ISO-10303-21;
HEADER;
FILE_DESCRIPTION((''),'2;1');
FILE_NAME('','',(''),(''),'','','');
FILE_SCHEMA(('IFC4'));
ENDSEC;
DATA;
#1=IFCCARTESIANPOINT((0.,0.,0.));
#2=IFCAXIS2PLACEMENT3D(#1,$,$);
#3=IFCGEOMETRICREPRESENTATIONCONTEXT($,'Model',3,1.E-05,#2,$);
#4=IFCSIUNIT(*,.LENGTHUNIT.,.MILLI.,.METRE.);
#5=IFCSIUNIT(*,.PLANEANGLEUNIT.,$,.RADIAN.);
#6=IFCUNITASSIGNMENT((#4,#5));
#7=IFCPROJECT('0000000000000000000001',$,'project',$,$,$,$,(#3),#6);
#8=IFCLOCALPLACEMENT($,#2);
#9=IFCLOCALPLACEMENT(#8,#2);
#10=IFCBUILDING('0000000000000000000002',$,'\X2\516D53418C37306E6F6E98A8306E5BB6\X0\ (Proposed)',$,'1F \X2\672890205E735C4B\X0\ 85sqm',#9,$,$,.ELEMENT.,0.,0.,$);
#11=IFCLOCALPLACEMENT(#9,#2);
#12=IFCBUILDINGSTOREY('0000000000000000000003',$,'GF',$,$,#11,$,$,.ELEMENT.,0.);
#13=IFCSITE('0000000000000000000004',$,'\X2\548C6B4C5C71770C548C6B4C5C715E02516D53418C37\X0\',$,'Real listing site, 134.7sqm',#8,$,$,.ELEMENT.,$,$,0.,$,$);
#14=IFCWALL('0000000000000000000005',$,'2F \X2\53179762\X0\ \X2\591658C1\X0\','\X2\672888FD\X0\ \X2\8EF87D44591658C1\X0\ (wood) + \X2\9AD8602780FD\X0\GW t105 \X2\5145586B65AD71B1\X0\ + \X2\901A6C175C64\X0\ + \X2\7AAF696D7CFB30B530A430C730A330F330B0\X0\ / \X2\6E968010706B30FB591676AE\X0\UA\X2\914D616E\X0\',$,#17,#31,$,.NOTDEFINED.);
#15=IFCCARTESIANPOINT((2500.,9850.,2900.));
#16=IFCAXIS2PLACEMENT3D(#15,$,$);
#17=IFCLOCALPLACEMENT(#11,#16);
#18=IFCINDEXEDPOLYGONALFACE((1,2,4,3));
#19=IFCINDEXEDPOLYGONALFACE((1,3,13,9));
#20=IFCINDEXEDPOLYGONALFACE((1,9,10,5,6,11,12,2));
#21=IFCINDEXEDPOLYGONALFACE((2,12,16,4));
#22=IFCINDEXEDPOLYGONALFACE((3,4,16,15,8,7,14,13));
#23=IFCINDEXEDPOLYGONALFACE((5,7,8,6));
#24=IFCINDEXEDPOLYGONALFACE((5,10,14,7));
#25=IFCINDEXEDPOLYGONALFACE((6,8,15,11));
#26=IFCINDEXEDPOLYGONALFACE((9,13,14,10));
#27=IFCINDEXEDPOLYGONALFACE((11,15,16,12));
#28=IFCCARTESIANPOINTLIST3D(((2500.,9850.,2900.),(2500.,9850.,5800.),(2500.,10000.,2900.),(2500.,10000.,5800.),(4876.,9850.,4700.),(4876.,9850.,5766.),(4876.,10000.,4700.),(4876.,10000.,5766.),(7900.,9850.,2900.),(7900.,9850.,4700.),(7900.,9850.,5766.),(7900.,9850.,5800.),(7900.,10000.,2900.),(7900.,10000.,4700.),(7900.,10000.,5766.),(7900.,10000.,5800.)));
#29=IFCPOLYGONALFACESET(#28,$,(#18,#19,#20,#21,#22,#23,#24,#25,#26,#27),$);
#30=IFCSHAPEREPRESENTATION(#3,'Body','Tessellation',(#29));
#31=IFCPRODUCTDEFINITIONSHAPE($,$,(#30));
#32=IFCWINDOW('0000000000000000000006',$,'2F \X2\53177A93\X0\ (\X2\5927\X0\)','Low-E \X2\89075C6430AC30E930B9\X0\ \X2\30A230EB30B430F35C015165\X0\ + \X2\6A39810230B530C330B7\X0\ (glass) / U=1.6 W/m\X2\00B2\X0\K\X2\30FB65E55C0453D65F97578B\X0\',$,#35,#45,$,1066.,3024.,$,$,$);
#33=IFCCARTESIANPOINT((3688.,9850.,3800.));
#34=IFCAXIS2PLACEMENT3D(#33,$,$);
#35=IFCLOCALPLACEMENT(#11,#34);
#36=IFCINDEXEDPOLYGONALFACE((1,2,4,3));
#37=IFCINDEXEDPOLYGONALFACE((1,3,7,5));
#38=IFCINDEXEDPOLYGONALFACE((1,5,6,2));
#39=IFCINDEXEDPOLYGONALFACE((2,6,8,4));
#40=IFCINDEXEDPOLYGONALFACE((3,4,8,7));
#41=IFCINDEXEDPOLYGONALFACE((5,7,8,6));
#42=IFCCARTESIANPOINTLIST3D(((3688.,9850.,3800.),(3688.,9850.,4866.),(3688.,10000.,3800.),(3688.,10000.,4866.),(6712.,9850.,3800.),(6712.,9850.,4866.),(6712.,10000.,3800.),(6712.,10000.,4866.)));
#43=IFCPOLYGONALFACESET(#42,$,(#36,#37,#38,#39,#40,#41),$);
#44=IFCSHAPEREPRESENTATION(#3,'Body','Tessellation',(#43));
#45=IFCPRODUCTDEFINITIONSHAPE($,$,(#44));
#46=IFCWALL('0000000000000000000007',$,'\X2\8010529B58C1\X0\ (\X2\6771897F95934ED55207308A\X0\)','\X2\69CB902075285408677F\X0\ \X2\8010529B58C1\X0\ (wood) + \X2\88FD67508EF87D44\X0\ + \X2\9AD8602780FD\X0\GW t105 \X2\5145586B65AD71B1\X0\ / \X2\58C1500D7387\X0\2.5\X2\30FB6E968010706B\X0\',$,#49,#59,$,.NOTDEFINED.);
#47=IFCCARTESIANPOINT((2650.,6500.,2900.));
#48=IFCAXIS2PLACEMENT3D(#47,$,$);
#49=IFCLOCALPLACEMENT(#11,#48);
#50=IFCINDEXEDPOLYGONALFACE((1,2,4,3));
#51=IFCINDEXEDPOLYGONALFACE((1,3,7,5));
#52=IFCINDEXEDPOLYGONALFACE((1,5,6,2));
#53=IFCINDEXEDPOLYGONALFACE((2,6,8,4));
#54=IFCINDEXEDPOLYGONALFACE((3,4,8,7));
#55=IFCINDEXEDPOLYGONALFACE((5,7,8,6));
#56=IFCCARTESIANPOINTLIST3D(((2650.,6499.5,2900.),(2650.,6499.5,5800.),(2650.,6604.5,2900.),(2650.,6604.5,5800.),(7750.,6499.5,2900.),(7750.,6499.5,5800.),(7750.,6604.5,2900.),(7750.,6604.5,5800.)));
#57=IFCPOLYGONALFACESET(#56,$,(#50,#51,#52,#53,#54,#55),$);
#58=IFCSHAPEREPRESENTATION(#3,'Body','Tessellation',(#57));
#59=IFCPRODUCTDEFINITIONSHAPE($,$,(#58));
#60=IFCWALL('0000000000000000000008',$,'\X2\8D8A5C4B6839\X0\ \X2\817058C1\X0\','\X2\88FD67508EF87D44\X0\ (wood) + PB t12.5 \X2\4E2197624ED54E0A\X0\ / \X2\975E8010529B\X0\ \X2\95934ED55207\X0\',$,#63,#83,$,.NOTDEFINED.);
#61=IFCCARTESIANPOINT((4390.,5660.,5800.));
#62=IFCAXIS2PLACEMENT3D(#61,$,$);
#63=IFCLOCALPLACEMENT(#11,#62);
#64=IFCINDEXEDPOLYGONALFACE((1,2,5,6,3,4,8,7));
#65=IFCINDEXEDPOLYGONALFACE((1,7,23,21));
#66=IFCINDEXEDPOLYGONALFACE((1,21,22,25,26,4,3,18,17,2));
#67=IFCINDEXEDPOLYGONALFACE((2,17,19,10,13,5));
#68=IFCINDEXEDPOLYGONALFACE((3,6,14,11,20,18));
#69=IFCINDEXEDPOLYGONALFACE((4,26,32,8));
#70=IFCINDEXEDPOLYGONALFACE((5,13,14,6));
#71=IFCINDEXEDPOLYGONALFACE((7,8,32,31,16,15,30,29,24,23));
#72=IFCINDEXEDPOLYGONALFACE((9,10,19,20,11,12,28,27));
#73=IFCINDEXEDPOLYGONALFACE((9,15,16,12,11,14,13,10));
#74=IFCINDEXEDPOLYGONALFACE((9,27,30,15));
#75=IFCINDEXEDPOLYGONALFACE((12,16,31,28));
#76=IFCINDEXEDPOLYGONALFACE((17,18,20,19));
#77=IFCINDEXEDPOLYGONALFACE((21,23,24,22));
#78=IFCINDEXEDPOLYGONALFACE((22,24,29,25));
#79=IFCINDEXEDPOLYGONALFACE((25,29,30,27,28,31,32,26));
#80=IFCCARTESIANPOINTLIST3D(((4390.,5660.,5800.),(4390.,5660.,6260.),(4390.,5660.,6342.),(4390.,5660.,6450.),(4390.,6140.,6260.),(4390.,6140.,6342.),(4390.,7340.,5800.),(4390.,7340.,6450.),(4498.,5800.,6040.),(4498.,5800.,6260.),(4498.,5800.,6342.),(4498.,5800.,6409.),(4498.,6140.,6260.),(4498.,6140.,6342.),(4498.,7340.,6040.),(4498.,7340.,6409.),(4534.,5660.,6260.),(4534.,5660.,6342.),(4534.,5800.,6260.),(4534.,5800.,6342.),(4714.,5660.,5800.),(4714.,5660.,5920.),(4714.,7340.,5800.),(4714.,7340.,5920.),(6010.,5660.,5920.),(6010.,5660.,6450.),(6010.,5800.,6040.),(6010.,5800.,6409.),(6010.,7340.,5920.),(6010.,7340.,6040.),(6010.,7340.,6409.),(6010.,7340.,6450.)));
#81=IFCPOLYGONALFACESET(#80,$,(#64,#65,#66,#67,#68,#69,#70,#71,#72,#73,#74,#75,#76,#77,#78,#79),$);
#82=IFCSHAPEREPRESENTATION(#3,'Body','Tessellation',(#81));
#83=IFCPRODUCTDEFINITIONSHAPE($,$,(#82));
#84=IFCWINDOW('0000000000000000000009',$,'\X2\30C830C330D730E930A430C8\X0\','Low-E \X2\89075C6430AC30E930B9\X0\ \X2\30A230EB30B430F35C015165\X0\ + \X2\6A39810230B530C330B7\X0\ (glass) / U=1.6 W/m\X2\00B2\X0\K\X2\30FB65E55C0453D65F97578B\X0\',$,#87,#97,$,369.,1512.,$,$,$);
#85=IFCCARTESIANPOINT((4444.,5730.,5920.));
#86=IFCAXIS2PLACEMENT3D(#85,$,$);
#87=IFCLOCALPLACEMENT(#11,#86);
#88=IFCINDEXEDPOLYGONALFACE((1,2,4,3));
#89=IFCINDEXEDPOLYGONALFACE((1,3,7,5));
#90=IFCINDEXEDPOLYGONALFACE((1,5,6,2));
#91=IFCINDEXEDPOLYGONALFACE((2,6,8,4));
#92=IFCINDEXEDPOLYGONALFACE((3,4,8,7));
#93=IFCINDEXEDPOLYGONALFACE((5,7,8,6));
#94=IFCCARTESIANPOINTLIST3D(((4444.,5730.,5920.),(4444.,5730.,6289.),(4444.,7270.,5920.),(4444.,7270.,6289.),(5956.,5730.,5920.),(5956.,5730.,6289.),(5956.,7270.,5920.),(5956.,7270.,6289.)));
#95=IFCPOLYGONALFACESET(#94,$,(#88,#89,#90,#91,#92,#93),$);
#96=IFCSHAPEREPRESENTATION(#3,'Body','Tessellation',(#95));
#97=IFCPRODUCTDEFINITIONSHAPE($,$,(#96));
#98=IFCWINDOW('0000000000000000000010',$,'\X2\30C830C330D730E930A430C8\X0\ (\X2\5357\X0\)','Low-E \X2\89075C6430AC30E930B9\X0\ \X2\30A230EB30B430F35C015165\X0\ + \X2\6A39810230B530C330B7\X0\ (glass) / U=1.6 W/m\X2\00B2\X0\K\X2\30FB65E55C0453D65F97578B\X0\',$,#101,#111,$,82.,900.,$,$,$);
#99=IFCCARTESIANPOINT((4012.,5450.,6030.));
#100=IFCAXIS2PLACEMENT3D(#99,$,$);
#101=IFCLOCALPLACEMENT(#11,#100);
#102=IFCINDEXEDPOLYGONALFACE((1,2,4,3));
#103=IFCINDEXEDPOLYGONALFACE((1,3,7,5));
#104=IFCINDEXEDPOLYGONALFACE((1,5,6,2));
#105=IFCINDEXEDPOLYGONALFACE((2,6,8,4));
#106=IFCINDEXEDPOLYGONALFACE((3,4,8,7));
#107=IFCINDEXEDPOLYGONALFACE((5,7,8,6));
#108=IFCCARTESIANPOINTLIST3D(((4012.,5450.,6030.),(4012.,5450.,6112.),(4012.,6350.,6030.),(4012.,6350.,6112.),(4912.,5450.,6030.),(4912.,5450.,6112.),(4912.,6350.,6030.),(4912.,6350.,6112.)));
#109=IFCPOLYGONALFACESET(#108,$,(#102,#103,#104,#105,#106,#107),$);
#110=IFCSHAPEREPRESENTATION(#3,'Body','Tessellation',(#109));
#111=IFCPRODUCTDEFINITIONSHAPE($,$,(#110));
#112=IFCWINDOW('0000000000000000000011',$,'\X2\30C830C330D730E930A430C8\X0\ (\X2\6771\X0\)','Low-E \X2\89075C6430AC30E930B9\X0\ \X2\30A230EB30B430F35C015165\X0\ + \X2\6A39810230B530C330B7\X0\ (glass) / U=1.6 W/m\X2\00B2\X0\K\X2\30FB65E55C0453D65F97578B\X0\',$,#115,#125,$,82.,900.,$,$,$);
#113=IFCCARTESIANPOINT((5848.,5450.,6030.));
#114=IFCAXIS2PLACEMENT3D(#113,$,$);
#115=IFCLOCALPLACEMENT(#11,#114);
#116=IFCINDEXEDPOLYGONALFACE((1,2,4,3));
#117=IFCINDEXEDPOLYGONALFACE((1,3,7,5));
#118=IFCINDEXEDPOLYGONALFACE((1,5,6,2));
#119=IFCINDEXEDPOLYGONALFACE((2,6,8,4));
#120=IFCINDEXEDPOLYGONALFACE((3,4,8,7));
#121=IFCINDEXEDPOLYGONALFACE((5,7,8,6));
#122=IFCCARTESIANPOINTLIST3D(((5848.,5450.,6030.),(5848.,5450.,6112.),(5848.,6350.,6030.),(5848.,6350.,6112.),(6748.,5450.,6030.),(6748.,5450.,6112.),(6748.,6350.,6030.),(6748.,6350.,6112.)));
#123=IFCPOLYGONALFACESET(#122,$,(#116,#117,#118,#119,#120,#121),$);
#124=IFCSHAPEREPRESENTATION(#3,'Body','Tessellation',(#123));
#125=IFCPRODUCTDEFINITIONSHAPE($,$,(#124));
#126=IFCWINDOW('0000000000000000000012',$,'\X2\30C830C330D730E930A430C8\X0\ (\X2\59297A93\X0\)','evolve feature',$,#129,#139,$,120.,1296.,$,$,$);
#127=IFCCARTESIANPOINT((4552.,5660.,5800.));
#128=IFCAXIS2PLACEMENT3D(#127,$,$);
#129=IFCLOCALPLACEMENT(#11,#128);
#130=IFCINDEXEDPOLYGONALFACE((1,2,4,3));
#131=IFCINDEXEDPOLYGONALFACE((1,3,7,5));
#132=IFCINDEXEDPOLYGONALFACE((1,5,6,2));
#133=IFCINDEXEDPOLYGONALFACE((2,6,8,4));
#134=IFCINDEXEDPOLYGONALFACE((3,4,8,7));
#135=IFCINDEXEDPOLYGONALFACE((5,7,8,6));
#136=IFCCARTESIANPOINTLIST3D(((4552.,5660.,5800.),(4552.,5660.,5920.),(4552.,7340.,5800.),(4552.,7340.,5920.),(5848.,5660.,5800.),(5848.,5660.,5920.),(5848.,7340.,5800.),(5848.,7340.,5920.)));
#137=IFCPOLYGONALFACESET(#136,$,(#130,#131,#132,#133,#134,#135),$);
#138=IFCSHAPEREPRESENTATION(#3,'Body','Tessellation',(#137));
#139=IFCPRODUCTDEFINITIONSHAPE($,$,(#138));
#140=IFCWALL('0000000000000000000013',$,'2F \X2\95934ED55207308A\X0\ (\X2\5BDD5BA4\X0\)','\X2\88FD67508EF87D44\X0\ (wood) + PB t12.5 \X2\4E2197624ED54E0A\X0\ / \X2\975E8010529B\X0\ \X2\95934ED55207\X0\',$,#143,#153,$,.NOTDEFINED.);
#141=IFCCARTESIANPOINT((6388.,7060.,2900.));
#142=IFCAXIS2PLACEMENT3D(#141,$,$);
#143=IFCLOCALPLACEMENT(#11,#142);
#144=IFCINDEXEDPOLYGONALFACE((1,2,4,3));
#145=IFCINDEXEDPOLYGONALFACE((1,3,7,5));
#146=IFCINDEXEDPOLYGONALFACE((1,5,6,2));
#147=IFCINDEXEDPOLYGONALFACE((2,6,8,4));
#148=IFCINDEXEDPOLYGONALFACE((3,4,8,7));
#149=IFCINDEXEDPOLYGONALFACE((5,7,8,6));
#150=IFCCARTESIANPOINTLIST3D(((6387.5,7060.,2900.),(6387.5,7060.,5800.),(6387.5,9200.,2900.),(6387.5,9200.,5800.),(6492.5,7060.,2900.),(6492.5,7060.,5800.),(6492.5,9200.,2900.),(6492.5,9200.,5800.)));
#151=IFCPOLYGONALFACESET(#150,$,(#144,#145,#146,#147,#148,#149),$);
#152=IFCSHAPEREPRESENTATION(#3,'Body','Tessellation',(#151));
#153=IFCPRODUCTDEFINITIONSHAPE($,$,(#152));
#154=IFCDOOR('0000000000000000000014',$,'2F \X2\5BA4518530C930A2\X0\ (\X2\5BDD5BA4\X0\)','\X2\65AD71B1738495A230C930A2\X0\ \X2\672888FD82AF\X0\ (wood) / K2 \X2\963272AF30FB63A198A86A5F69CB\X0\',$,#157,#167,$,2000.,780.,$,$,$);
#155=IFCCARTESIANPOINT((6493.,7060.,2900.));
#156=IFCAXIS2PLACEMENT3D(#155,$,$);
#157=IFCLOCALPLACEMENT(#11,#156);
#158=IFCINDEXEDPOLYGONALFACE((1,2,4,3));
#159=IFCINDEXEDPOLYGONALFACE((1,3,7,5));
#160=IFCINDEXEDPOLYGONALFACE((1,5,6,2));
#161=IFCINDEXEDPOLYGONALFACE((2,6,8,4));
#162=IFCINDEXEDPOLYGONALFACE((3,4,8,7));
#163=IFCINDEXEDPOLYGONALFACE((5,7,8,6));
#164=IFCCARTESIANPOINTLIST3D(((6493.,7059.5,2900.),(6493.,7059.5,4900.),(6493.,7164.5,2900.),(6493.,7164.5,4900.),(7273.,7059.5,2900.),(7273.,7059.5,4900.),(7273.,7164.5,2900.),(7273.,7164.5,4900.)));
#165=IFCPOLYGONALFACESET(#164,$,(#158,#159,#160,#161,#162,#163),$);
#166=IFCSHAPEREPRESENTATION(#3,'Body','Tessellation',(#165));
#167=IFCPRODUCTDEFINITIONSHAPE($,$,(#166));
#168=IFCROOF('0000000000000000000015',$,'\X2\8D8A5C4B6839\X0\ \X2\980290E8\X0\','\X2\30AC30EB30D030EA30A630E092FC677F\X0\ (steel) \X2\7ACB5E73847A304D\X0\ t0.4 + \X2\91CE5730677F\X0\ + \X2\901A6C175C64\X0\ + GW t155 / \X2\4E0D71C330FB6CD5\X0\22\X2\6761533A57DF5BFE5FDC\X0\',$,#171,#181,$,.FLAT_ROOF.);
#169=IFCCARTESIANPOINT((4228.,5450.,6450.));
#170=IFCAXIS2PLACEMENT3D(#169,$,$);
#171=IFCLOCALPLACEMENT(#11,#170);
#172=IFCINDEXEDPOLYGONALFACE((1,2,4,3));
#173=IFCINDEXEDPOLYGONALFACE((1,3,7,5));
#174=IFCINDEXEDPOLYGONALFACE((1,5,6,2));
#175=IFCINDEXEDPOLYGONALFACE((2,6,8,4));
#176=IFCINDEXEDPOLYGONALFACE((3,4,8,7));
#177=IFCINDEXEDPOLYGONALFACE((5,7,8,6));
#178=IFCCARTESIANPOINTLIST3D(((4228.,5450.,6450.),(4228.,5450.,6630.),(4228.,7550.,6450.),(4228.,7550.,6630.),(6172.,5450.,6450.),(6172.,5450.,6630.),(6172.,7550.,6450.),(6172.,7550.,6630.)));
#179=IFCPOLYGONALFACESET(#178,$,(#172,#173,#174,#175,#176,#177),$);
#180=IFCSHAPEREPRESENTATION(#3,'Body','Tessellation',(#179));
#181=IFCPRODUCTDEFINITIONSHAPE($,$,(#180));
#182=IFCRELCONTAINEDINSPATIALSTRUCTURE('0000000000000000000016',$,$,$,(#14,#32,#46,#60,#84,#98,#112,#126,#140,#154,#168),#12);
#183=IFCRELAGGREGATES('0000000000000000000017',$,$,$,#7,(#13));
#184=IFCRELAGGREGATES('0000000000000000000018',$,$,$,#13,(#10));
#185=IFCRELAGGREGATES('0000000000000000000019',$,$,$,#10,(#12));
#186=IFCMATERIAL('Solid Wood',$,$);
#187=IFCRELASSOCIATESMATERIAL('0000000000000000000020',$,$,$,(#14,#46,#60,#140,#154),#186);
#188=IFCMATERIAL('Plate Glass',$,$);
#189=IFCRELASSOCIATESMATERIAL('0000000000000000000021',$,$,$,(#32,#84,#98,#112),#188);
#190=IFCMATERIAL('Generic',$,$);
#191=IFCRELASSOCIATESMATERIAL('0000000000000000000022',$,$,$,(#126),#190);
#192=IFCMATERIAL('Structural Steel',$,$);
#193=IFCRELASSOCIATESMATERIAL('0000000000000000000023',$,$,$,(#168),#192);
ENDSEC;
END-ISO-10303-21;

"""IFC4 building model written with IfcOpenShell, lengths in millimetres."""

from ifc_helpers import new_model, si_unit, frame, frame_2d, origin, place, context, project, spatial, rectangle, extrude, material, element, fill, save


model = new_model("IFC4")

# Units and contexts
model_context = context("Model", 3, precision=1e-05, world=origin())
ifc_project = project(units=[si_unit("LENGTHUNIT", "METRE", prefix="MILLI"), si_unit("PLANEANGLEUNIT", "RADIAN")], contexts=[model_context])

# Site, building, storey
site_placement = place(None, origin())
site = spatial("IfcSite", under=ifc_project, at=site_placement, Name="和歌山県和歌山市六十谷", ObjectType="Real listing site, 134.7sqm", CompositionType="ELEMENT", RefElevation=0.0)
building_placement = place(site_placement, origin())
building = spatial("IfcBuilding", under=site, at=building_placement, Name="六十谷の潮風の家 (Proposed)", ObjectType="1F 木造平屋 85sqm", CompositionType="ELEMENT", ElevationOfRefHeight=0.0, ElevationOfTerrain=0.0)
storey_placement = place(building_placement, origin())
storey = spatial("IfcBuildingStorey", under=building, at=storey_placement, Name="GF", CompositionType="ELEMENT", Elevation=0.0)

# Wall, opening, window
ifc_material_1 = material(Name="Solid Wood")
wall_1_placement = place(storey_placement, frame((2500.0, 9850.0, 2900.0)))
wall_1 = element("IfcWall", 1, at=wall_1_placement, inside=storey, material=ifc_material_1, Name="2F 北面 外壁", Description="木製 軸組外壁 (wood) + 高性能GW t105 充填断熱 + 通気層 + 窯業系サイディング / 準耐火・外皮UA配慮", PredefinedType="NOTDEFINED", context=model_context, shape_type="SweptSolid", body=[
    extrude(rectangle(XDim=5400.0, YDim=150.0, at=frame_2d((2700.0, 75.0))), frame((2500.0, 9850.0, 2900.0)), (0.0, 0.0, 1.0), 2900.0),
])
opening_1_placement = place(storey_placement, frame((3688.0, 9850.0, 3800.0)))
opening_1 = element("IfcOpeningElement", 2, at=opening_1_placement, cuts=wall_1, PredefinedType="NOTDEFINED", context=model_context, shape_type="SweptSolid", body=[
    extrude(rectangle(XDim=3024.0, YDim=150.0, at=frame_2d((1512.0, 75.0))), frame((3688.0, 9850.0, 3800.0)), (0.0, 0.0, 1.0), 1066.0),
])
ifc_material_2 = material(Name="Plate Glass")
window_1_placement = place(storey_placement, frame((3688.0, 9850.0, 3800.0)))
window_1 = element("IfcWindow", 3, at=window_1_placement, inside=storey, material=ifc_material_2, Name="2F 北窓 (大)", Description="Low-E 複層ガラス アルゴン封入 + 樹脂サッシ (glass) / U=1.6 W/m²K・日射取得型", OverallHeight=1066.0, OverallWidth=3024.0, context=model_context, shape_type="SweptSolid", body=[
    extrude(rectangle(XDim=3024.0, YDim=150.0, at=frame_2d((1512.0, 75.0))), frame((3688.0, 9850.0, 3800.0)), (0.0, 0.0, 1.0), 1066.0),
])
fill(opening_1, window_1)

# Wall
wall_2_placement = place(storey_placement, frame((2650.0, 6500.0, 2900.0)))
element("IfcWall", 4, at=wall_2_placement, inside=storey, material=ifc_material_1, Name="耐力壁 (東西間仕切り)", Description="構造用合板 耐力壁 (wood) + 製材軸組 + 高性能GW t105 充填断熱 / 壁倍率2.5・準耐火", PredefinedType="NOTDEFINED", context=model_context, shape_type="SweptSolid", body=[
    extrude(rectangle(XDim=5100.0, YDim=105.0, at=frame_2d((2550.0, 52.0))), frame((2650.0, 6500.0, 2900.0)), (0.0, 0.0, 1.0), 2900.0),
])

# Wall, openings, windows
wall_3_placement = place(storey_placement, frame((4390.0, 5660.0, 5800.0)))
wall_3 = element("IfcWall", 5, at=wall_3_placement, inside=storey, material=ifc_material_1, Name="越屋根 腰壁", Description="製材軸組 (wood) + PB t12.5 両面仕上 / 非耐力 間仕切", PredefinedType="NOTDEFINED", context=model_context, shape_type="SweptSolid", body=[
    extrude(rectangle(XDim=1620.0, YDim=1680.0, at=frame_2d((810.0, 840.0))), frame((4390.0, 5660.0, 5800.0)), (0.0, 0.0, 1.0), 650.0),
])
opening_2_placement = place(storey_placement, frame((4444.0, 5730.0, 5920.0)))
opening_2 = element("IfcOpeningElement", 6, at=opening_2_placement, cuts=wall_3, PredefinedType="NOTDEFINED", context=model_context, shape_type="SweptSolid", body=[
    extrude(rectangle(XDim=1512.0, YDim=1540.0, at=frame_2d((756.0, 770.0))), frame((4444.0, 5730.0, 5920.0)), (0.0, 0.0, 1.0), 369.0),
])
opening_3_placement = place(storey_placement, frame((4012.0, 5450.0, 6030.0)))
opening_3 = element("IfcOpeningElement", 7, at=opening_3_placement, cuts=wall_3, PredefinedType="NOTDEFINED", context=model_context, shape_type="SweptSolid", body=[
    extrude(rectangle(XDim=900.0, YDim=900.0, at=frame_2d((450.0, 450.0))), frame((4012.0, 5450.0, 6030.0)), (0.0, 0.0, 1.0), 82.0),
])
opening_4_placement = place(storey_placement, frame((5848.0, 5450.0, 6030.0)))
opening_4 = element("IfcOpeningElement", 8, at=opening_4_placement, cuts=wall_3, PredefinedType="NOTDEFINED", context=model_context, shape_type="SweptSolid", body=[
    extrude(rectangle(XDim=900.0, YDim=900.0, at=frame_2d((450.0, 450.0))), frame((5848.0, 5450.0, 6030.0)), (0.0, 0.0, 1.0), 82.0),
])
opening_5_placement = place(storey_placement, frame((4552.0, 5660.0, 5800.0)))
opening_5 = element("IfcOpeningElement", 9, at=opening_5_placement, cuts=wall_3, PredefinedType="NOTDEFINED", context=model_context, shape_type="SweptSolid", body=[
    extrude(rectangle(XDim=1296.0, YDim=1680.0, at=frame_2d((648.0, 840.0))), frame((4552.0, 5660.0, 5800.0)), (0.0, 0.0, 1.0), 120.0),
])
window_2_placement = place(storey_placement, frame((4444.0, 5730.0, 5920.0)))
window_2 = element("IfcWindow", 10, at=window_2_placement, inside=storey, material=ifc_material_2, Name="トップライト", Description="Low-E 複層ガラス アルゴン封入 + 樹脂サッシ (glass) / U=1.6 W/m²K・日射取得型", OverallHeight=369.0, OverallWidth=1512.0, context=model_context, shape_type="SweptSolid", body=[
    extrude(rectangle(XDim=1512.0, YDim=1540.0, at=frame_2d((756.0, 770.0))), frame((4444.0, 5730.0, 5920.0)), (0.0, 0.0, 1.0), 369.0),
])
fill(opening_2, window_2)
window_3_placement = place(storey_placement, frame((4012.0, 5450.0, 6030.0)))
window_3 = element("IfcWindow", 11, at=window_3_placement, inside=storey, material=ifc_material_2, Name="トップライト (南)", Description="Low-E 複層ガラス アルゴン封入 + 樹脂サッシ (glass) / U=1.6 W/m²K・日射取得型", OverallHeight=82.0, OverallWidth=900.0, context=model_context, shape_type="SweptSolid", body=[
    extrude(rectangle(XDim=900.0, YDim=900.0, at=frame_2d((450.0, 450.0))), frame((4012.0, 5450.0, 6030.0)), (0.0, 0.0, 1.0), 82.0),
])
fill(opening_3, window_3)
window_4_placement = place(storey_placement, frame((5848.0, 5450.0, 6030.0)))
window_4 = element("IfcWindow", 12, at=window_4_placement, inside=storey, material=ifc_material_2, Name="トップライト (東)", Description="Low-E 複層ガラス アルゴン封入 + 樹脂サッシ (glass) / U=1.6 W/m²K・日射取得型", OverallHeight=82.0, OverallWidth=900.0, context=model_context, shape_type="SweptSolid", body=[
    extrude(rectangle(XDim=900.0, YDim=900.0, at=frame_2d((450.0, 450.0))), frame((5848.0, 5450.0, 6030.0)), (0.0, 0.0, 1.0), 82.0),
])
fill(opening_4, window_4)
ifc_material_3 = material(Name="Generic")
window_5_placement = place(storey_placement, frame((4552.0, 5660.0, 5800.0)))
window_5 = element("IfcWindow", 13, at=window_5_placement, inside=storey, material=ifc_material_3, Name="トップライト (天窓)", Description="evolve feature", OverallHeight=120.0, OverallWidth=1296.0, context=model_context, shape_type="SweptSolid", body=[
    extrude(rectangle(XDim=1296.0, YDim=1680.0, at=frame_2d((648.0, 840.0))), frame((4552.0, 5660.0, 5800.0)), (0.0, 0.0, 1.0), 120.0),
])
fill(opening_5, window_5)

# Wall
wall_4_placement = place(storey_placement, frame((6388.0, 7060.0, 2900.0)))
element("IfcWall", 14, at=wall_4_placement, inside=storey, material=ifc_material_1, Name="2F 間仕切り (寝室)", Description="製材軸組 (wood) + PB t12.5 両面仕上 / 非耐力 間仕切", PredefinedType="NOTDEFINED", context=model_context, shape_type="SweptSolid", body=[
    extrude(rectangle(XDim=105.0, YDim=2140.0, at=frame_2d((52.0, 1070.0))), frame((6388.0, 7060.0, 2900.0)), (0.0, 0.0, 1.0), 2900.0),
])

# Door
door_placement = place(storey_placement, frame((6493.0, 7060.0, 2900.0)))
element("IfcDoor", 15, at=door_placement, inside=storey, material=ifc_material_1, Name="2F 室内ドア (寝室)", Description="断熱玄関ドア 木製芯 (wood) / K2 防犯・採風機構", OverallHeight=2000.0, OverallWidth=780.0, context=model_context, shape_type="SweptSolid", body=[
    extrude(rectangle(XDim=780.0, YDim=105.0, at=frame_2d((390.0, 52.0))), frame((6493.0, 7060.0, 2900.0)), (0.0, 0.0, 1.0), 2000.0),
])

# Roof
ifc_material_4 = material(Name="Structural Steel")
roof_placement = place(storey_placement, frame((4228.0, 5450.0, 6450.0)))
element("IfcRoof", 16, at=roof_placement, inside=storey, material=ifc_material_4, Name="越屋根 頂部", Description="ガルバリウム鋼板 (steel) 立平葺き t0.4 + 野地板 + 通気層 + GW t155 / 不燃・法22条区域対応", PredefinedType="FLAT_ROOF", context=model_context, shape_type="SweptSolid", body=[
    extrude(rectangle(XDim=1944.0, YDim=2100.0, at=frame_2d((972.0, 1050.0))), frame((4228.0, 5450.0, 6450.0)), (0.0, 0.0, 1.0), 180.0),
])

save(model, "model.ifc")
